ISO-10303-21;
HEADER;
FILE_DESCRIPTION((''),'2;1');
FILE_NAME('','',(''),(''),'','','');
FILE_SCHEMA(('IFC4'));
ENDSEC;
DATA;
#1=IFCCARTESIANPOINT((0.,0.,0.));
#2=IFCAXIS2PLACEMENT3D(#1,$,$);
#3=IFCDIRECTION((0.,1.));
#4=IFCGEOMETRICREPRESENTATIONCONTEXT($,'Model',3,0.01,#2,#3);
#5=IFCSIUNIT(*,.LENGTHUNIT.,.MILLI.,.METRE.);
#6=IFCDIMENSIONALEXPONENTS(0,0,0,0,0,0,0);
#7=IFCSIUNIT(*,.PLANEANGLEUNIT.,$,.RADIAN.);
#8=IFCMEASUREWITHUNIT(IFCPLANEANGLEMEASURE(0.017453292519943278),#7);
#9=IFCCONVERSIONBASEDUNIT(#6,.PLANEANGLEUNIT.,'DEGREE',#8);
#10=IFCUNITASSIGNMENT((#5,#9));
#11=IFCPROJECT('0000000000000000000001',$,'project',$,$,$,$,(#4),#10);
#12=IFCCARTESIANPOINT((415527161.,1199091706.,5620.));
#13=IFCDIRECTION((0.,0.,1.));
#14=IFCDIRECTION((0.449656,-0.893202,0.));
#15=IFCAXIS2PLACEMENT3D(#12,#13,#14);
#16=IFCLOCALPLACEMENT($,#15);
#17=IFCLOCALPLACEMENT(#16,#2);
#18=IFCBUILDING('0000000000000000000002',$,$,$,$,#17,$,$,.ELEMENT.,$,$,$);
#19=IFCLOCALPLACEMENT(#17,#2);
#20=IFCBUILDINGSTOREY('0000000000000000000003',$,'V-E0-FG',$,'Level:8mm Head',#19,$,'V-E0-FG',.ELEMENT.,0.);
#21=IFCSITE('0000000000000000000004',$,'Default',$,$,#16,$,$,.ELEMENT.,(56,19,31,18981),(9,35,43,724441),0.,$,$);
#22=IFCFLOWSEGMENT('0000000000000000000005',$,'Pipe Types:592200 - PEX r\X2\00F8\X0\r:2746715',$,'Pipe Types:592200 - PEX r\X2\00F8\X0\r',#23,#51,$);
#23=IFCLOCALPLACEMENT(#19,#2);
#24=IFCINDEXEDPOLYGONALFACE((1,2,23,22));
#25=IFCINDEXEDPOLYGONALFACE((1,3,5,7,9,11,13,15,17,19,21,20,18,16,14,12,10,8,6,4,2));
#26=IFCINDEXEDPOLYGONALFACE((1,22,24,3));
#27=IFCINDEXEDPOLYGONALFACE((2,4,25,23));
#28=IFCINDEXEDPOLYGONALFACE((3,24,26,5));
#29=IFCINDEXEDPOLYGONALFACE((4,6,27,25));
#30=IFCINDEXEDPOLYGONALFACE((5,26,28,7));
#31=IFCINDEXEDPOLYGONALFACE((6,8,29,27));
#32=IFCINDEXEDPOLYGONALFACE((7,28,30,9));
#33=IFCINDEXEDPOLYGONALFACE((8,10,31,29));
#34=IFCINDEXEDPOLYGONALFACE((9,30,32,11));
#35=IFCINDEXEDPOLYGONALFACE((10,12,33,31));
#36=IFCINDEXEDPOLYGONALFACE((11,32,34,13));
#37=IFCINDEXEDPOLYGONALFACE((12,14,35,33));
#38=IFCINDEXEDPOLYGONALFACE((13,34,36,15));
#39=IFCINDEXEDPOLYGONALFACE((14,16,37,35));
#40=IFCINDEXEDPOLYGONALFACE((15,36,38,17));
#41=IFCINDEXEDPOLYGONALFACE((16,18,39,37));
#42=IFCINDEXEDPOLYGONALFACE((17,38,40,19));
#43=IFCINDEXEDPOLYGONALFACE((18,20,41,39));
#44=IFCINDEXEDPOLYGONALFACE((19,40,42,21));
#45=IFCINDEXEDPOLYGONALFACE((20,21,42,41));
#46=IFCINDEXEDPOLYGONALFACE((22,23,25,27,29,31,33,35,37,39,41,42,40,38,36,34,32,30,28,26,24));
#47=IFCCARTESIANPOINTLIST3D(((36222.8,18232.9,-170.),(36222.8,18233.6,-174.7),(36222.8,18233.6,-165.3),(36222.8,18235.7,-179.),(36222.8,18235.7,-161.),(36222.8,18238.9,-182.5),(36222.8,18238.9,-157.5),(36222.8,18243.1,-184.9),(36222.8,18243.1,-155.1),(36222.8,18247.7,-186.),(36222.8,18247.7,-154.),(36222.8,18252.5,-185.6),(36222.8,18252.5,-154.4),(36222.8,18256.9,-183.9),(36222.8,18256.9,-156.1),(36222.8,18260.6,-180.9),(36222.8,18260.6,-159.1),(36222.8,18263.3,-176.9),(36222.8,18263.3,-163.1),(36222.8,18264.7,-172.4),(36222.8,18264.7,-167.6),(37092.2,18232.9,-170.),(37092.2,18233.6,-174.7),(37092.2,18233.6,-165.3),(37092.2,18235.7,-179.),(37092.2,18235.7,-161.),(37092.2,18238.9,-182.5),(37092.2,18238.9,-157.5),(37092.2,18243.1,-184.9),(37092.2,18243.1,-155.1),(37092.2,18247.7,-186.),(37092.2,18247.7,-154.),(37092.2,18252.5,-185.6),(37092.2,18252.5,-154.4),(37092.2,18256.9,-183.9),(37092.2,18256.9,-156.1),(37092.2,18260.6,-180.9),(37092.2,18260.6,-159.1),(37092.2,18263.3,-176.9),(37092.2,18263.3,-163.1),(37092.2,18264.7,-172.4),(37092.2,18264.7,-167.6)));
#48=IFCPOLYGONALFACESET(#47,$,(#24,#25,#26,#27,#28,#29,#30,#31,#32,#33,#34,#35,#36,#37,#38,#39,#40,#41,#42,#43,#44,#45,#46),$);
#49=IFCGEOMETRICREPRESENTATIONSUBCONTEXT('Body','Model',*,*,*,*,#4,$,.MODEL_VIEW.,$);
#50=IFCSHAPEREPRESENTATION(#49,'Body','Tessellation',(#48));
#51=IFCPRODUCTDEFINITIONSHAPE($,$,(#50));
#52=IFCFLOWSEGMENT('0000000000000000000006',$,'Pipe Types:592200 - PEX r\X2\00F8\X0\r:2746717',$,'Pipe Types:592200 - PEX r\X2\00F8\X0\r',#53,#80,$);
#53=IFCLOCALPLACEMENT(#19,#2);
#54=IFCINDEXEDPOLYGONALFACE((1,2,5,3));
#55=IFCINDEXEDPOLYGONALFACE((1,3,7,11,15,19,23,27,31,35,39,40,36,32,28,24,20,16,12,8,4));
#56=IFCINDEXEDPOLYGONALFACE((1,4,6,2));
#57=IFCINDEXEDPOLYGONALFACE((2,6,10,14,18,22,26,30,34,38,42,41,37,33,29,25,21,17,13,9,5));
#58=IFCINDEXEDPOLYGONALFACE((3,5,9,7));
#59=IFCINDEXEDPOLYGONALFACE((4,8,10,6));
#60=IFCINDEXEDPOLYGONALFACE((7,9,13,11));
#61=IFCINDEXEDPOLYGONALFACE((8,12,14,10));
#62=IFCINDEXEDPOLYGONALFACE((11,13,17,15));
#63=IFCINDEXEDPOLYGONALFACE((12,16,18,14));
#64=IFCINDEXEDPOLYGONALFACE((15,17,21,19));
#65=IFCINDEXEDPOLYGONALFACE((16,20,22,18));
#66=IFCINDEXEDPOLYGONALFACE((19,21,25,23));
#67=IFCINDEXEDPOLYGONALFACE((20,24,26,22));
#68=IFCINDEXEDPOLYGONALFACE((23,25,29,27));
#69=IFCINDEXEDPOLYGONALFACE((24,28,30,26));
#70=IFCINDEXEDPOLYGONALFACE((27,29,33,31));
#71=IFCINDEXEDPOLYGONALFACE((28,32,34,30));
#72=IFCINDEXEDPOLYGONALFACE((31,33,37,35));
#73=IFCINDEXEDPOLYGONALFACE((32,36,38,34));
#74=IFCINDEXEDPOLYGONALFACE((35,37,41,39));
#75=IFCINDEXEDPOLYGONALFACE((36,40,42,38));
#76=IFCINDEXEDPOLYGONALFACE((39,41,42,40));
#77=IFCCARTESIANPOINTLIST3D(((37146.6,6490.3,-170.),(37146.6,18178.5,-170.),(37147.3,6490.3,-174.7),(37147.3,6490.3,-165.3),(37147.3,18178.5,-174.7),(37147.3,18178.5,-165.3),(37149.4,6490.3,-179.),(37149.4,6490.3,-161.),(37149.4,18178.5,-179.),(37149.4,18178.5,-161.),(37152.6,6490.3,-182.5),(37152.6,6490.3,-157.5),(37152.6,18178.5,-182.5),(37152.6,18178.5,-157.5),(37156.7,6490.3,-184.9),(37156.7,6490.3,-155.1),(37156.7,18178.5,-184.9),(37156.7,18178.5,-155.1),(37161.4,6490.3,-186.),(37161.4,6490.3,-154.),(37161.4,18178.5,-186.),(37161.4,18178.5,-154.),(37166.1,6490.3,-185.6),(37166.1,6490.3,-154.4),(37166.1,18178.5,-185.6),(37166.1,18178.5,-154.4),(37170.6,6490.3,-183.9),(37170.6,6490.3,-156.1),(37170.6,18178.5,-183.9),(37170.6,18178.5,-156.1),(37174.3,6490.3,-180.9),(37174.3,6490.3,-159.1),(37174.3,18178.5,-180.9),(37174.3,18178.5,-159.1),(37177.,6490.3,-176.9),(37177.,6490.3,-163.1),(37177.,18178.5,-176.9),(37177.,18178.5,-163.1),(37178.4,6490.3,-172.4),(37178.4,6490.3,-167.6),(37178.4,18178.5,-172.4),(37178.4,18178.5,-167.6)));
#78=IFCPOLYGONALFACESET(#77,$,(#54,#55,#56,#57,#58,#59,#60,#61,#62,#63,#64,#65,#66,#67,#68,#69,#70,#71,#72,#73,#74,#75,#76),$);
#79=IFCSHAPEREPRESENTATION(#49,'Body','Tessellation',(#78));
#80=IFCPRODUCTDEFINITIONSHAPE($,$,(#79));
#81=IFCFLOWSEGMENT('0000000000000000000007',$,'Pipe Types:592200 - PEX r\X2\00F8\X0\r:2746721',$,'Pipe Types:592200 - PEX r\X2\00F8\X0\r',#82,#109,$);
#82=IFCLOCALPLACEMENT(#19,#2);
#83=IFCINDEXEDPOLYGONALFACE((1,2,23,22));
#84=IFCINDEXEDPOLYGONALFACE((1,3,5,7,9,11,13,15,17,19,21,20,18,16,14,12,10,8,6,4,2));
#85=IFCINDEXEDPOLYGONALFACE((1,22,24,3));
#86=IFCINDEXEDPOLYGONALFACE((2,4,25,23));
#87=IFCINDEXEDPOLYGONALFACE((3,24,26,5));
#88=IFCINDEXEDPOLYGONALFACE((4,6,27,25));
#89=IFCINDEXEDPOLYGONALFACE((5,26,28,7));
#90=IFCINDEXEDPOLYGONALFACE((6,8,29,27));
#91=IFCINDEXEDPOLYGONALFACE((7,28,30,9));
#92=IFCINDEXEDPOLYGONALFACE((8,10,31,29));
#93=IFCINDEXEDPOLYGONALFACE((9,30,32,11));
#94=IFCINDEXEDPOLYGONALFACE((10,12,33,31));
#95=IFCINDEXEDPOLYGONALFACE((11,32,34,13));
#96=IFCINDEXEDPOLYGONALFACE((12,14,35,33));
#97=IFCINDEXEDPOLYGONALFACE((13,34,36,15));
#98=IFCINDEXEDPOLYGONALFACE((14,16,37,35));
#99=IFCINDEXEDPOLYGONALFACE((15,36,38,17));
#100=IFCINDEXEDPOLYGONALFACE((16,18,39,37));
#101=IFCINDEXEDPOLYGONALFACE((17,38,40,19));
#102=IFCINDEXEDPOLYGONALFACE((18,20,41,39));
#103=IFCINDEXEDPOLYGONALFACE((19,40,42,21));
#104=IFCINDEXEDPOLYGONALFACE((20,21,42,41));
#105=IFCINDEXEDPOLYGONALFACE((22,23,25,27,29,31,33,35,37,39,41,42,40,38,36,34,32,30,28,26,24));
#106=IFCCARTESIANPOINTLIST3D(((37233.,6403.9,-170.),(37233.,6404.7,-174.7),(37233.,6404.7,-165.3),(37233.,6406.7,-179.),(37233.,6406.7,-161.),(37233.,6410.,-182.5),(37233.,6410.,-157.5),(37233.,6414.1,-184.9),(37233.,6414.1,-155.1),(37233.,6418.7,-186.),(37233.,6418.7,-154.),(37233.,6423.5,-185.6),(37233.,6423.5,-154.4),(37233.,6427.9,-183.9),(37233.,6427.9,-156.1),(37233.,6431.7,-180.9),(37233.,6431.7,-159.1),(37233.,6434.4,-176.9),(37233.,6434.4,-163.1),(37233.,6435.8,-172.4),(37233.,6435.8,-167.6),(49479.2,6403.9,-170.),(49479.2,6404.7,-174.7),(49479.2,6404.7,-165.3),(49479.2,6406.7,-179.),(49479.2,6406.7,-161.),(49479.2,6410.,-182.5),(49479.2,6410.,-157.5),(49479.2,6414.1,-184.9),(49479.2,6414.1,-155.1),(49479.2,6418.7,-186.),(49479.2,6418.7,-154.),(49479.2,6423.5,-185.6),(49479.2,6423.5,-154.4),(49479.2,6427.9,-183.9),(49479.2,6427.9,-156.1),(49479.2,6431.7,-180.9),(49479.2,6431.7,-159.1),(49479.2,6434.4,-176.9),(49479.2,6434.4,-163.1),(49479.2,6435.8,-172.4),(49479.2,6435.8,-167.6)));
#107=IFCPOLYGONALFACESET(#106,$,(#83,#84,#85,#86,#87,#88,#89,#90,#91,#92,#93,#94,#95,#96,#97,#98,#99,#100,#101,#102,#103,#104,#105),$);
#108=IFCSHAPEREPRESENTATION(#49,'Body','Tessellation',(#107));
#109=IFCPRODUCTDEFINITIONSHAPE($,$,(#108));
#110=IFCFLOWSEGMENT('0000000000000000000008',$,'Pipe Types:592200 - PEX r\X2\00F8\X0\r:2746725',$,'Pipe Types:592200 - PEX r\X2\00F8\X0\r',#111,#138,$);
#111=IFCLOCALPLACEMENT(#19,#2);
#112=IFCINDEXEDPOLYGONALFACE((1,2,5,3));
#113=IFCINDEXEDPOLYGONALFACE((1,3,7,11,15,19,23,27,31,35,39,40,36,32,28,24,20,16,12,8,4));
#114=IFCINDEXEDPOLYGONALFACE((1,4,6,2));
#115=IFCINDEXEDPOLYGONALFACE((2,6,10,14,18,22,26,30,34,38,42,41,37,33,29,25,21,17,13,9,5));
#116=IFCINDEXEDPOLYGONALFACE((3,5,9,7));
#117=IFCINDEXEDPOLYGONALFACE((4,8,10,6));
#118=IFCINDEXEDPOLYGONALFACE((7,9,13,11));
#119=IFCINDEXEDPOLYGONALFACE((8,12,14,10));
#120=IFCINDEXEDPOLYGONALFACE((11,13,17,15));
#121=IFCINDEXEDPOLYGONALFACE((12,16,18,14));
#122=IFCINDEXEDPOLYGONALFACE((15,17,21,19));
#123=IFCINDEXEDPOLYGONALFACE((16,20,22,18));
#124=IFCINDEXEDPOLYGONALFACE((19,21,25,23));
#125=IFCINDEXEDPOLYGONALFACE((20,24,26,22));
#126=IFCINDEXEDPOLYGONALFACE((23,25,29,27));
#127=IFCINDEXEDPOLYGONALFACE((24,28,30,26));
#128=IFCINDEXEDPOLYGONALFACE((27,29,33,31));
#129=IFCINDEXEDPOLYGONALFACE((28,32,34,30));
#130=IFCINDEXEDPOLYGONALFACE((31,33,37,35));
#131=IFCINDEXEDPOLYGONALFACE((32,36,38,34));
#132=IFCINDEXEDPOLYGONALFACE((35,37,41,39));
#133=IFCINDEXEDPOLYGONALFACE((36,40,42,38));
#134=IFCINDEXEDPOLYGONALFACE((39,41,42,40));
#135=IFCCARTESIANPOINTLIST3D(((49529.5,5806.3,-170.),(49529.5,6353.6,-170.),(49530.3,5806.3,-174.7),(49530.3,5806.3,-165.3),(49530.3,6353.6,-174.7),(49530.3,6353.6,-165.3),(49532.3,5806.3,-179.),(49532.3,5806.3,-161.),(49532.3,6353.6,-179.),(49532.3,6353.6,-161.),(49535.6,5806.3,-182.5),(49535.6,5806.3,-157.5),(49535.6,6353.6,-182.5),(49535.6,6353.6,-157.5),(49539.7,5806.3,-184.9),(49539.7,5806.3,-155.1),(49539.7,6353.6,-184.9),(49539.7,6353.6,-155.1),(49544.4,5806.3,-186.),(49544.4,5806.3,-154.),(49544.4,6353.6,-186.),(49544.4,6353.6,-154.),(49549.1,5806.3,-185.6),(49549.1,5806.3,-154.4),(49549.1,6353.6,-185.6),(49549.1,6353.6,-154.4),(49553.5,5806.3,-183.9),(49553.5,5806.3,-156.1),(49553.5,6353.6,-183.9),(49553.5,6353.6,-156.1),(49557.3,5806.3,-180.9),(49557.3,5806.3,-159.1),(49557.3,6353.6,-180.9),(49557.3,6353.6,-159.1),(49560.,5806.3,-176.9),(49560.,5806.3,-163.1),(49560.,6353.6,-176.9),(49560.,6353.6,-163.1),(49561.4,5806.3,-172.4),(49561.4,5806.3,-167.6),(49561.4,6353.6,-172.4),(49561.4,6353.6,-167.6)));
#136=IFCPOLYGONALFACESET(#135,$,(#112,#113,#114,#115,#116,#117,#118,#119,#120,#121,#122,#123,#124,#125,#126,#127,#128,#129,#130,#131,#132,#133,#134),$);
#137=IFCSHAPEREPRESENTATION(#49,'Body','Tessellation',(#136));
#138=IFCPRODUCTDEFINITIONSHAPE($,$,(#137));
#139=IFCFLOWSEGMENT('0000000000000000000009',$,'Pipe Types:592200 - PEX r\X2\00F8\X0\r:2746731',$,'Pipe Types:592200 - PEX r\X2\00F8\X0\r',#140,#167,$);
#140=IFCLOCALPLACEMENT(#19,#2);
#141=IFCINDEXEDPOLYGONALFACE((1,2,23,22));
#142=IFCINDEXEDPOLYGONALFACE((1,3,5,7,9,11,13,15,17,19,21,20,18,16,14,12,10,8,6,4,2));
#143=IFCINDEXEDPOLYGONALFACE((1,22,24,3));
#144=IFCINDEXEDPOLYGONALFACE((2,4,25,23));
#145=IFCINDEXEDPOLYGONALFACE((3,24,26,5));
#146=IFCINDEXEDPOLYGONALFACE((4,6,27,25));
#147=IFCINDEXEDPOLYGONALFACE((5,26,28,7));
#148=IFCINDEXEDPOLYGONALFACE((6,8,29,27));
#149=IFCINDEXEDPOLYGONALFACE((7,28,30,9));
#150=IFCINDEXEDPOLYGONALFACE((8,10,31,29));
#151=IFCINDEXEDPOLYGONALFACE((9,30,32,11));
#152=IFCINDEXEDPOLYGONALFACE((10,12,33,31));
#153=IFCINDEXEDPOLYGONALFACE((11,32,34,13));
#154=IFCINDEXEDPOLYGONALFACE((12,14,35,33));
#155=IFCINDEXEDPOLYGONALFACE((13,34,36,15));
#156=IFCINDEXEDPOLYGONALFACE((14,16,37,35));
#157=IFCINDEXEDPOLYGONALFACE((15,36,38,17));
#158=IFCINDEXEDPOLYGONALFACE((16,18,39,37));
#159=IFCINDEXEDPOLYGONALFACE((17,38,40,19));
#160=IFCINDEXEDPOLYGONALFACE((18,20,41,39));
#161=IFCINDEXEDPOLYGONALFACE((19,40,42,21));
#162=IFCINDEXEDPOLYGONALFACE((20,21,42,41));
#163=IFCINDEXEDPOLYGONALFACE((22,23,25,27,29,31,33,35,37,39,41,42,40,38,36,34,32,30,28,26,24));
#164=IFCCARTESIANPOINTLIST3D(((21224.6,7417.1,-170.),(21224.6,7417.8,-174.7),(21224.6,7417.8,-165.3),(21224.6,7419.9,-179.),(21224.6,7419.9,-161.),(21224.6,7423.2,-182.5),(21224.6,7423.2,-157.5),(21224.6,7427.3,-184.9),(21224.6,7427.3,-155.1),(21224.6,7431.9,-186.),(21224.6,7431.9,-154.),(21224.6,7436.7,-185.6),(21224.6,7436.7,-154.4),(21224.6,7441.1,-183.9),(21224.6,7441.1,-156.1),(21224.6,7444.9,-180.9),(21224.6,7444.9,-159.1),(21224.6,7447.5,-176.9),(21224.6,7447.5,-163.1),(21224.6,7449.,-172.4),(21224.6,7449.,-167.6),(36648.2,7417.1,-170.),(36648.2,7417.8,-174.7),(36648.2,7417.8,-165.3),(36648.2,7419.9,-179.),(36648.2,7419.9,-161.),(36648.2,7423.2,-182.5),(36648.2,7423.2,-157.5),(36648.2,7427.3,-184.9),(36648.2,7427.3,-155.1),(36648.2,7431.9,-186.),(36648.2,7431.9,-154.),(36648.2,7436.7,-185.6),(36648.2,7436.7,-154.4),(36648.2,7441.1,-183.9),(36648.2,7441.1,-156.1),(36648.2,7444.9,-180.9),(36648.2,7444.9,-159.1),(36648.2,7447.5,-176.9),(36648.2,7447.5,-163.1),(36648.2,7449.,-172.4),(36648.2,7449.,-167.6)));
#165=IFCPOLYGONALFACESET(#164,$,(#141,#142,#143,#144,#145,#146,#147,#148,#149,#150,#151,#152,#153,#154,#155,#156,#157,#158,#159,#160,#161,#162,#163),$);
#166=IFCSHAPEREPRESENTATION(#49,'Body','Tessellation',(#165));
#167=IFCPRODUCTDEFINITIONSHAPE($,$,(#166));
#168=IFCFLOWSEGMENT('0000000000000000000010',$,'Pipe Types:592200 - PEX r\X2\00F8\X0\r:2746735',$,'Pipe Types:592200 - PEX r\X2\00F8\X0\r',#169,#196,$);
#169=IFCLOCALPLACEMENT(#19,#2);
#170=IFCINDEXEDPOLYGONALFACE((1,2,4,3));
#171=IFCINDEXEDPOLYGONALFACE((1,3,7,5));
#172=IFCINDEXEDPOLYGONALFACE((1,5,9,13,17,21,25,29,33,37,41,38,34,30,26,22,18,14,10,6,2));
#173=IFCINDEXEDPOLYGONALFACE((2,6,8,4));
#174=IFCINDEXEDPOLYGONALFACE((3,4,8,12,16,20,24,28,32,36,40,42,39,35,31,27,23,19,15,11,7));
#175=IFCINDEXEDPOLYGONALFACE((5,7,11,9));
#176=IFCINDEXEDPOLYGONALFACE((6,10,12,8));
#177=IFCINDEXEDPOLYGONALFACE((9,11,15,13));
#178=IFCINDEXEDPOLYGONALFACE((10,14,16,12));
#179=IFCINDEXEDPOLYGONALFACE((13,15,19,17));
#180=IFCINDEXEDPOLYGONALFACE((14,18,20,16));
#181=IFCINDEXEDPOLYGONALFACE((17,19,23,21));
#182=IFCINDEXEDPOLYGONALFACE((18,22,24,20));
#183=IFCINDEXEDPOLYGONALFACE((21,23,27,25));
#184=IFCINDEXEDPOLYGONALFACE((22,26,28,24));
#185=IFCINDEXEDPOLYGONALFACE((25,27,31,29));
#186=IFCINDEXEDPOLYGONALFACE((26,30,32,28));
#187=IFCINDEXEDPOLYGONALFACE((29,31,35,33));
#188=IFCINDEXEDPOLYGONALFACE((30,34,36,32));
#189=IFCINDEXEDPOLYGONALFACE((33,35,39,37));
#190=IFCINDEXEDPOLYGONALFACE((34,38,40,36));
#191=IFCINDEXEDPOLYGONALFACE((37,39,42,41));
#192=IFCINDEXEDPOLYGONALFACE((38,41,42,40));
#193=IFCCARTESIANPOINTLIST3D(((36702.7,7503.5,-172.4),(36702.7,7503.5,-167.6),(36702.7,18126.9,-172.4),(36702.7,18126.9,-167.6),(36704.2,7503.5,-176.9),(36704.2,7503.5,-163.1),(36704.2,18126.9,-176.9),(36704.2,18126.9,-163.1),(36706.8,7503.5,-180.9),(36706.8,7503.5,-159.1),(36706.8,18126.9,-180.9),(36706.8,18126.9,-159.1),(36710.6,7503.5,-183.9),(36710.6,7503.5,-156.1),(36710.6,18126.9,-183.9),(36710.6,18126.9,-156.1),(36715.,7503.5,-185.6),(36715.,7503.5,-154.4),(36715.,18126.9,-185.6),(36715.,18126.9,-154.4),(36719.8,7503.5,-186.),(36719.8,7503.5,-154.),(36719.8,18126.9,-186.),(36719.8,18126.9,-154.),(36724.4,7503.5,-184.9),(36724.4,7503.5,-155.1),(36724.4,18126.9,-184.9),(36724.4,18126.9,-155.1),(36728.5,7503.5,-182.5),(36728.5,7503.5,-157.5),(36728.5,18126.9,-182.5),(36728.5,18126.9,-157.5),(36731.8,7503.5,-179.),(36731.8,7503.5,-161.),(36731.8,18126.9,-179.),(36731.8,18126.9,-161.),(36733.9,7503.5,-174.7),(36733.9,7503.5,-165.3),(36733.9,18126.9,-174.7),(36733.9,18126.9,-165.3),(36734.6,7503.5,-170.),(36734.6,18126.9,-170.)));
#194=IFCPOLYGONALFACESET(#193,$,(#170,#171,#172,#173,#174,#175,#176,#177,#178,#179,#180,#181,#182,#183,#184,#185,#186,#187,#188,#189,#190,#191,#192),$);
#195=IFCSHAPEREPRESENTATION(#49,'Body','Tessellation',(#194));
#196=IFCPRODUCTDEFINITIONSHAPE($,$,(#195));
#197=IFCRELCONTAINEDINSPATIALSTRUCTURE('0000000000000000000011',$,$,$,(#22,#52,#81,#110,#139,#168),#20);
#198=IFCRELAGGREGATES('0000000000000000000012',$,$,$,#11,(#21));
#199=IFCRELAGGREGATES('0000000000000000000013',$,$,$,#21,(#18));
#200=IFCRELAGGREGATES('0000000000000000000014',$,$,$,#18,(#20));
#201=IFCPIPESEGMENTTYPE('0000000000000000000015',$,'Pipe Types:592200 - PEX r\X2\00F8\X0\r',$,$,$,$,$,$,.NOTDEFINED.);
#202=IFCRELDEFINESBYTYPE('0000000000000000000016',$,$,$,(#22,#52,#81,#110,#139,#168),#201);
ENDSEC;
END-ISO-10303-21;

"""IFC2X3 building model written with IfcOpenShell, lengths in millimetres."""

from ifc_helpers import new_model, entity, si_unit, converted_unit, direction, frame, frame_2d, origin, origin_2d_with_axis, place, context, subcontext, project, spatial, circle, extrude, type_object, element, save


model = new_model("IFC2X3")

# Units and contexts
model_context = context("Model", 3, precision=0.01, world=origin(), true_north=direction((0.0, 1.0)))
body_context = subcontext(model_context, "Body", "Model", "MODEL_VIEW")
ifc_project = project(units=[si_unit("LENGTHUNIT", "METRE", prefix="MILLI"), converted_unit("PLANEANGLEUNIT", "DEGREE", entity("IfcPlaneAngleMeasure", 0.017453292519943278), si_unit("PLANEANGLEUNIT", "RADIAN"), dimensions=[0, 0, 0, 0, 0, 0, 0])], contexts=[model_context])

# Site, building, storey
site_placement = place(None, frame((415527161.0, 1199091706.0, 5620.0), z_axis=(0.0, 0.0, 1.0), x_axis=(0.449656, -0.893202, 0.0)))
site = spatial("IfcSite", under=ifc_project, at=site_placement, Name="Default", CompositionType="ELEMENT", RefLatitude=(56, 19, 31, 18981), RefLongitude=(9, 35, 43, 724441), RefElevation=0.0)
building_placement = place(site_placement, origin())
building = spatial("IfcBuilding", under=site, at=building_placement, CompositionType="ELEMENT")
storey_placement = place(building_placement, origin())
storey = spatial("IfcBuildingStorey", under=building, at=storey_placement, Name="V-E0-FG", ObjectType="Level:8mm Head", LongName="V-E0-FG", CompositionType="ELEMENT", Elevation=0.0)

# Flow segments
pipe_segment_type_1 = type_object("IfcPipeSegmentType", Name="Pipe Types:592200 - PEX rør", PredefinedType="NOTDEFINED")
flow_segment_1_placement = place(storey_placement, origin())
element("IfcFlowSegment", 1, at=flow_segment_1_placement, inside=storey, type_object=pipe_segment_type_1, Name="Pipe Types:592200 - PEX rør:2746715", ObjectType="Pipe Types:592200 - PEX rør", context=body_context, shape_type="SweptSolid", body=[
    extrude(circle(Radius=16.0, at=origin_2d_with_axis()), frame((36222.8, 18248.9, -170.0), z_axis=(1.0, 0.0, 0.0), x_axis=(0.0, -1.0, 0.0)), (0.0, 0.0, 1.0), 869.4),
])
flow_segment_2_placement = place(storey_placement, origin())
element("IfcFlowSegment", 2, at=flow_segment_2_placement, inside=storey, type_object=pipe_segment_type_1, Name="Pipe Types:592200 - PEX rør:2746717", ObjectType="Pipe Types:592200 - PEX rør", context=body_context, shape_type="SweptSolid", body=[
    extrude(circle(Radius=16.0, at=frame_2d((0.0, 0.0), x_axis=(1.0, 0.0))), frame((37162.6, 6490.3, -170.0), z_axis=(0.0, 1.0, 0.0), x_axis=(-1.0, 0.0, 0.0)), (0.0, 0.0, 1.0), 11688.2),
])
flow_segment_3_placement = place(storey_placement, origin())
element("IfcFlowSegment", 3, at=flow_segment_3_placement, inside=storey, type_object=pipe_segment_type_1, Name="Pipe Types:592200 - PEX rør:2746721", ObjectType="Pipe Types:592200 - PEX rør", context=body_context, shape_type="SweptSolid", body=[
    extrude(circle(Radius=16.0, at=origin_2d_with_axis()), frame((37233.0, 6419.9, -170.0), z_axis=(1.0, 0.0, 0.0), x_axis=(0.0, -1.0, 0.0)), (0.0, 0.0, 1.0), 12246.3),
])
flow_segment_4_placement = place(storey_placement, origin())
element("IfcFlowSegment", 4, at=flow_segment_4_placement, inside=storey, type_object=pipe_segment_type_1, Name="Pipe Types:592200 - PEX rør:2746725", ObjectType="Pipe Types:592200 - PEX rør", context=body_context, shape_type="SweptSolid", body=[
    extrude(circle(Radius=16.0, at=origin_2d_with_axis()), frame((49545.5, 5806.3, -170.0), z_axis=(0.0, 1.0, 0.0), x_axis=(-1.0, 0.0, 0.0)), (0.0, 0.0, 1.0), 547.4),
])
flow_segment_5_placement = place(storey_placement, origin())
element("IfcFlowSegment", 5, at=flow_segment_5_placement, inside=storey, type_object=pipe_segment_type_1, Name="Pipe Types:592200 - PEX rør:2746731", ObjectType="Pipe Types:592200 - PEX rør", context=body_context, shape_type="SweptSolid", body=[
    extrude(circle(Radius=16.0, at=origin_2d_with_axis()), frame((21224.6, 7433.1, -170.0), z_axis=(1.0, 0.0, 0.0), x_axis=(0.0, -1.0, 0.0)), (0.0, 0.0, 1.0), 15423.6),
])
flow_segment_6_placement = place(storey_placement, origin())
element("IfcFlowSegment", 6, at=flow_segment_6_placement, inside=storey, type_object=pipe_segment_type_1, Name="Pipe Types:592200 - PEX rør:2746735", ObjectType="Pipe Types:592200 - PEX rør", context=body_context, shape_type="SweptSolid", body=[
    extrude(circle(Radius=16.0, at=origin_2d_with_axis()), frame((36718.6, 7503.5, -170.0), z_axis=(0.0, 1.0, 0.0), x_axis=(1.0, 0.0, 0.0)), (0.0, 0.0, 1.0), 10623.4),
])

save(model, "model.ifc")
